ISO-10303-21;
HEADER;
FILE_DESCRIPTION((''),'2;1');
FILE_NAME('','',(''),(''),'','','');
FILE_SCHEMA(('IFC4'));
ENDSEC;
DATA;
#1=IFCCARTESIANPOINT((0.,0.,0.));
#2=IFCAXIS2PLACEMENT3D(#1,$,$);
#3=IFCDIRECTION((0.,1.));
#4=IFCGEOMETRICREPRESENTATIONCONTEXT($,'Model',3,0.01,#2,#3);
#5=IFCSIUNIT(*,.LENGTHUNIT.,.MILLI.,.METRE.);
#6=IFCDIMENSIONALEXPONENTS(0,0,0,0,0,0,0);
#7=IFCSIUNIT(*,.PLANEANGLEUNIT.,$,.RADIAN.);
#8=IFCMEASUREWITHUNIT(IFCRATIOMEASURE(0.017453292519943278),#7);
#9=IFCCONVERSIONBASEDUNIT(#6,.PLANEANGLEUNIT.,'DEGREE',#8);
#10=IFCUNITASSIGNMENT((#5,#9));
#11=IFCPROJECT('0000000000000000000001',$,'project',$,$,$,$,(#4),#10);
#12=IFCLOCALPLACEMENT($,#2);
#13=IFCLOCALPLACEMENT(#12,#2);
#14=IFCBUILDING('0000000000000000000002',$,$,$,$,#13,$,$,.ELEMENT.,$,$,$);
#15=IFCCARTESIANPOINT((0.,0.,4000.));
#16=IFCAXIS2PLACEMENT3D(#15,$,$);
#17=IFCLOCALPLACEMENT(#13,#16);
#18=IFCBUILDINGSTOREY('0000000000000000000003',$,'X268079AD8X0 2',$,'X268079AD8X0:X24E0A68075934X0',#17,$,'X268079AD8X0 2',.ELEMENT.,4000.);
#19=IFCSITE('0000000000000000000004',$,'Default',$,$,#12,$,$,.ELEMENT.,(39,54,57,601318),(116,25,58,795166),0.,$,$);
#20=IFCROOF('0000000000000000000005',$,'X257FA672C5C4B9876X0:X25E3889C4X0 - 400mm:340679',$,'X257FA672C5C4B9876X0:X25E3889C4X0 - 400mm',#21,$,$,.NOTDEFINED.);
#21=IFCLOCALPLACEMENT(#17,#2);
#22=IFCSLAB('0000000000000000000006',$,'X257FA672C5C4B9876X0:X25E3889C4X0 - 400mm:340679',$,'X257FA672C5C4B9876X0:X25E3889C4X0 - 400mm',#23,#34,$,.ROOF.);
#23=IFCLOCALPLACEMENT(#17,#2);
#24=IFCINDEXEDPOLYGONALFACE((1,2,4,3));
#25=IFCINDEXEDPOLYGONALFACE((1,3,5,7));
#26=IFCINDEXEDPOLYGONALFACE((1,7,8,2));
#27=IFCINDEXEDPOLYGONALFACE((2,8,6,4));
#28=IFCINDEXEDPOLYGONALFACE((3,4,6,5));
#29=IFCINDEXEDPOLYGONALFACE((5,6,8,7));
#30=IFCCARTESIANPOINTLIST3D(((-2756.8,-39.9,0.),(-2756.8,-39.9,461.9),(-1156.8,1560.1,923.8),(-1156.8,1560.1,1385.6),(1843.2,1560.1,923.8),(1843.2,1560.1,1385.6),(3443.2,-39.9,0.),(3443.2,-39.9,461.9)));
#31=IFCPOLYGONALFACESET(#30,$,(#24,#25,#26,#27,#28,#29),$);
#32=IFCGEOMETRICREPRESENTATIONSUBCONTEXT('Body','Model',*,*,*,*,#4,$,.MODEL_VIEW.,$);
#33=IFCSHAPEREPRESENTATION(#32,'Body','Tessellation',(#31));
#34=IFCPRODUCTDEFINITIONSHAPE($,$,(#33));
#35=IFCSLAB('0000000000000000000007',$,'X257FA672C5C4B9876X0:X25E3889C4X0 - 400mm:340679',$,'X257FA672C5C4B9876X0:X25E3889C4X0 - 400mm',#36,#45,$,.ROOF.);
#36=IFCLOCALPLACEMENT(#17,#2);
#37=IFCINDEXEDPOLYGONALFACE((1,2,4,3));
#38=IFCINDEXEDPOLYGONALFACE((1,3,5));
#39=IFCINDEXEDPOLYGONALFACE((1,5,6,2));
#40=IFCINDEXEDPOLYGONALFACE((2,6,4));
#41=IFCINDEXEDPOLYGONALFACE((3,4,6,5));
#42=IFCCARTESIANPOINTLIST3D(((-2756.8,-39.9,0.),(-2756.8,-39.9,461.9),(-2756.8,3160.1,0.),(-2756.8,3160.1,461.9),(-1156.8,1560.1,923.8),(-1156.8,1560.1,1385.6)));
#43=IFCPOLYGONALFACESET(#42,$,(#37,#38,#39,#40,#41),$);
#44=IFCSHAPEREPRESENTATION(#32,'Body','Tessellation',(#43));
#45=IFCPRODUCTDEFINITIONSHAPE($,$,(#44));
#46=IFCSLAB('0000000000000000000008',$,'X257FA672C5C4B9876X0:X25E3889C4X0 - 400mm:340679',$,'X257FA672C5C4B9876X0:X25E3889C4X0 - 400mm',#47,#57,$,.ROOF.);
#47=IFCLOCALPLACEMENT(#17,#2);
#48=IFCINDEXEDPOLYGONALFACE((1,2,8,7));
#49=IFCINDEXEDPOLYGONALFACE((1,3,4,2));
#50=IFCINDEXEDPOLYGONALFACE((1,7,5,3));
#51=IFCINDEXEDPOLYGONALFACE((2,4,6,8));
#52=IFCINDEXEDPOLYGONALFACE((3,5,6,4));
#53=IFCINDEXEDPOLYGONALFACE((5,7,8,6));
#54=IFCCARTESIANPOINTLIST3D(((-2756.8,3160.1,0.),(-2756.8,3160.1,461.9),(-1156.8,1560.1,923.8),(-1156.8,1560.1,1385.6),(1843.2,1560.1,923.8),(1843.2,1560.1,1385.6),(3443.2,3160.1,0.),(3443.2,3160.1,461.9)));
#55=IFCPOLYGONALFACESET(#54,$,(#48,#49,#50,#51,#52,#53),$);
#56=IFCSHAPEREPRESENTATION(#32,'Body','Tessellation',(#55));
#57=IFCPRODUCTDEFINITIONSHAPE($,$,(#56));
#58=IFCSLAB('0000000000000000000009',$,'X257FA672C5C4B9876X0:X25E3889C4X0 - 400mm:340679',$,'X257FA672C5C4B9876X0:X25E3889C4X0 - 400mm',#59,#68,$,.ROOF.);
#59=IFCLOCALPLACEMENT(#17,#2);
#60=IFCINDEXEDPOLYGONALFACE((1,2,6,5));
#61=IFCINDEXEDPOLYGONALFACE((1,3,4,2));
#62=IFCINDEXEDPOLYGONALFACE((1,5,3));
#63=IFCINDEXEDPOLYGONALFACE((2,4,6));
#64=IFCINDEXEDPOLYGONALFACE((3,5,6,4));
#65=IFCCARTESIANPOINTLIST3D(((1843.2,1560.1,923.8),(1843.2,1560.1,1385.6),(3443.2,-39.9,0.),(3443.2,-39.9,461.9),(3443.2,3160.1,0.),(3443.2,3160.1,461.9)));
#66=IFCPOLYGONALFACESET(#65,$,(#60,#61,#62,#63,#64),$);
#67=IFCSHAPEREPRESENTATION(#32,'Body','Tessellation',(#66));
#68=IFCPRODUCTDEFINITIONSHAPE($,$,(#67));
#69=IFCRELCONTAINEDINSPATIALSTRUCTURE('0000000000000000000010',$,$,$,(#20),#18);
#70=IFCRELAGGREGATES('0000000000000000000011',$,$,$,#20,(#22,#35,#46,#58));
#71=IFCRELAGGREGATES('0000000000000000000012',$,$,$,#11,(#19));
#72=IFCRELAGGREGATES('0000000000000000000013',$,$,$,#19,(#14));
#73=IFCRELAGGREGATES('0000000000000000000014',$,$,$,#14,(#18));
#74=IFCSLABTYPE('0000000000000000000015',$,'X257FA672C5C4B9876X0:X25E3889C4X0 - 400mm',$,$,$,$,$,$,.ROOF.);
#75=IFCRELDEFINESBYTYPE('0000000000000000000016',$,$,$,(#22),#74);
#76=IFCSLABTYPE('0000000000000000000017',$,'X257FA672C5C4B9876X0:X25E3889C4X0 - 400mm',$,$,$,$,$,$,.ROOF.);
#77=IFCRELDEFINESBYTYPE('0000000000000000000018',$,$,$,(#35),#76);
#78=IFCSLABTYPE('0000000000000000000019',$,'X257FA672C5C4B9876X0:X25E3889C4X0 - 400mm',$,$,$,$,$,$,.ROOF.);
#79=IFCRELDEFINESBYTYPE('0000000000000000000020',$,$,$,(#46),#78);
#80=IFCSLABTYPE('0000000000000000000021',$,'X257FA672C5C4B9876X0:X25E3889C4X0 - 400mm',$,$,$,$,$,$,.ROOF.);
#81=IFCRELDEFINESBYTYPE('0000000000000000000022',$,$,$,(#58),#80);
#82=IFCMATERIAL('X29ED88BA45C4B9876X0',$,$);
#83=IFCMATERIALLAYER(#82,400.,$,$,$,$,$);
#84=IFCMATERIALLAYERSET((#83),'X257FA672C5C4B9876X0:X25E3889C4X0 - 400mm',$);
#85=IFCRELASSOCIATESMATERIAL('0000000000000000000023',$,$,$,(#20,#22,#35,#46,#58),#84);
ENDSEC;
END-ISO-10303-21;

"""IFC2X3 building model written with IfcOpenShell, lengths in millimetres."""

from ifc_helpers import new_model, entity, si_unit, converted_unit, direction, frame, origin, place, context, subcontext, project, spatial, polyline, outline, extrude, material, layer, layer_set, type_object, element, aggregate, save


model = new_model("IFC2X3")

# Units and contexts
model_context = context("Model", 3, precision=0.01, world=origin(), true_north=direction((0.0, 1.0)))
body_context = subcontext(model_context, "Body", "Model", "MODEL_VIEW")
ifc_project = project(units=[si_unit("LENGTHUNIT", "METRE", prefix="MILLI"), converted_unit("PLANEANGLEUNIT", "DEGREE", entity("IfcRatioMeasure", 0.017453292519943278), si_unit("PLANEANGLEUNIT", "RADIAN"), dimensions=[0, 0, 0, 0, 0, 0, 0])], contexts=[model_context])

# Site, building, storey
site_placement = place(None, origin())
site = spatial("IfcSite", under=ifc_project, at=site_placement, Name="Default", CompositionType="ELEMENT", RefLatitude=(39, 54, 57, 601318), RefLongitude=(116, 25, 58, 795166), RefElevation=0.0)
building_placement = place(site_placement, origin())
building = spatial("IfcBuilding", under=site, at=building_placement, CompositionType="ELEMENT")
storey_placement = place(building_placement, frame((0.0, 0.0, 4000.0)))
storey = spatial("IfcBuildingStorey", under=building, at=storey_placement, Name="X268079AD8X0 2", ObjectType="X268079AD8X0:X24E0A68075934X0", LongName="X268079AD8X0 2", CompositionType="ELEMENT", Elevation=4000.0)

# Roof, slabs
ifc_material = material(Name="X29ED88BA45C4B9876X0")
ifc_layer = layer(ifc_material, 400.0)
ifc_layer_set = layer_set([ifc_layer], Name="X257FA672C5C4B9876X0:X25E3889C4X0 - 400mm")
roof_placement = place(storey_placement, frame((-2756.8, -39.9, 0.0)))
roof = element("IfcRoof", 1, at=roof_placement, inside=storey, material=ifc_layer_set, Name="X257FA672C5C4B9876X0:X25E3889C4X0 - 400mm:340679", ObjectType="X257FA672C5C4B9876X0:X25E3889C4X0 - 400mm", ShapeType="NOTDEFINED")
slab_type_1 = type_object("IfcSlabType", Name="X257FA672C5C4B9876X0:X25E3889C4X0 - 400mm", PredefinedType="ROOF")
slab_1_placement = place(roof_placement, origin())
slab_1 = element("IfcSlab", 2, at=slab_1_placement, type_object=slab_type_1, material=ifc_layer_set, Name="X257FA672C5C4B9876X0:X25E3889C4X0 - 400mm:340679", ObjectType="X257FA672C5C4B9876X0:X25E3889C4X0 - 400mm", PredefinedType="ROOF", context=body_context, shape_type="SweptSolid", body=[
    extrude(outline(polyline([(1500.0, 923.8), (-1500.0, 923.8), (-3100.0, -923.8), (3100.0, -923.8), (1500.0, 923.8)])), frame((3100.0, 800.0, 461.9), z_axis=(0.0, -0.5, 0.866025), x_axis=(1.0, 0.0, 0.0)), (0.0, 0.5, 0.866025), 461.9),
])
slab_type_2 = type_object("IfcSlabType", Name="X257FA672C5C4B9876X0:X25E3889C4X0 - 400mm", PredefinedType="ROOF")
slab_2_placement = place(roof_placement, origin())
slab_2 = element("IfcSlab", 3, at=slab_2_placement, type_object=slab_type_2, material=ifc_layer_set, Name="X257FA672C5C4B9876X0:X25E3889C4X0 - 400mm:340679", ObjectType="X257FA672C5C4B9876X0:X25E3889C4X0 - 400mm", PredefinedType="ROOF", context=body_context, shape_type="SweptSolid", body=[
    extrude(outline(polyline([(-923.8, 1600.0), (-923.8, -1600.0), (923.8, 0.0), (-923.8, 1600.0)])), frame((800.0, 1600.0, 461.9), z_axis=(-0.5, 0.0, 0.866025), x_axis=(0.866025, 0.0, 0.5)), (0.5, 0.0, 0.866025), 461.9),
])
slab_type_3 = type_object("IfcSlabType", Name="X257FA672C5C4B9876X0:X25E3889C4X0 - 400mm", PredefinedType="ROOF")
slab_3_placement = place(roof_placement, origin())
slab_3 = element("IfcSlab", 4, at=slab_3_placement, type_object=slab_type_3, material=ifc_layer_set, Name="X257FA672C5C4B9876X0:X25E3889C4X0 - 400mm:340679", ObjectType="X257FA672C5C4B9876X0:X25E3889C4X0 - 400mm", PredefinedType="ROOF", context=body_context, shape_type="SweptSolid", body=[
    extrude(outline(polyline([(3100.0, 923.8), (-3100.0, 923.8), (-1500.0, -923.8), (1500.0, -923.8), (3100.0, 923.8)])), frame((3100.0, 2400.0, 461.9), z_axis=(0.0, 0.5, 0.866025), x_axis=(1.0, 0.0, 0.0)), (0.0, -0.5, 0.866025), 461.9),
])
slab_type_4 = type_object("IfcSlabType", Name="X257FA672C5C4B9876X0:X25E3889C4X0 - 400mm", PredefinedType="ROOF")
slab_4_placement = place(roof_placement, origin())
slab_4 = element("IfcSlab", 5, at=slab_4_placement, type_object=slab_type_4, material=ifc_layer_set, Name="X257FA672C5C4B9876X0:X25E3889C4X0 - 400mm:340679", ObjectType="X257FA672C5C4B9876X0:X25E3889C4X0 - 400mm", PredefinedType="ROOF", context=body_context, shape_type="SweptSolid", body=[
    extrude(outline(polyline([(923.8, -1600.0), (923.8, 1600.0), (-923.8, 0.0), (923.8, -1600.0)])), frame((5400.0, 1600.0, 461.9), z_axis=(0.5, 0.0, 0.866025), x_axis=(0.866025, 0.0, -0.5)), (-0.5, 0.0, 0.866025), 461.9),
])
aggregate(roof, [slab_1, slab_2, slab_3, slab_4])

save(model, "model.ifc")
